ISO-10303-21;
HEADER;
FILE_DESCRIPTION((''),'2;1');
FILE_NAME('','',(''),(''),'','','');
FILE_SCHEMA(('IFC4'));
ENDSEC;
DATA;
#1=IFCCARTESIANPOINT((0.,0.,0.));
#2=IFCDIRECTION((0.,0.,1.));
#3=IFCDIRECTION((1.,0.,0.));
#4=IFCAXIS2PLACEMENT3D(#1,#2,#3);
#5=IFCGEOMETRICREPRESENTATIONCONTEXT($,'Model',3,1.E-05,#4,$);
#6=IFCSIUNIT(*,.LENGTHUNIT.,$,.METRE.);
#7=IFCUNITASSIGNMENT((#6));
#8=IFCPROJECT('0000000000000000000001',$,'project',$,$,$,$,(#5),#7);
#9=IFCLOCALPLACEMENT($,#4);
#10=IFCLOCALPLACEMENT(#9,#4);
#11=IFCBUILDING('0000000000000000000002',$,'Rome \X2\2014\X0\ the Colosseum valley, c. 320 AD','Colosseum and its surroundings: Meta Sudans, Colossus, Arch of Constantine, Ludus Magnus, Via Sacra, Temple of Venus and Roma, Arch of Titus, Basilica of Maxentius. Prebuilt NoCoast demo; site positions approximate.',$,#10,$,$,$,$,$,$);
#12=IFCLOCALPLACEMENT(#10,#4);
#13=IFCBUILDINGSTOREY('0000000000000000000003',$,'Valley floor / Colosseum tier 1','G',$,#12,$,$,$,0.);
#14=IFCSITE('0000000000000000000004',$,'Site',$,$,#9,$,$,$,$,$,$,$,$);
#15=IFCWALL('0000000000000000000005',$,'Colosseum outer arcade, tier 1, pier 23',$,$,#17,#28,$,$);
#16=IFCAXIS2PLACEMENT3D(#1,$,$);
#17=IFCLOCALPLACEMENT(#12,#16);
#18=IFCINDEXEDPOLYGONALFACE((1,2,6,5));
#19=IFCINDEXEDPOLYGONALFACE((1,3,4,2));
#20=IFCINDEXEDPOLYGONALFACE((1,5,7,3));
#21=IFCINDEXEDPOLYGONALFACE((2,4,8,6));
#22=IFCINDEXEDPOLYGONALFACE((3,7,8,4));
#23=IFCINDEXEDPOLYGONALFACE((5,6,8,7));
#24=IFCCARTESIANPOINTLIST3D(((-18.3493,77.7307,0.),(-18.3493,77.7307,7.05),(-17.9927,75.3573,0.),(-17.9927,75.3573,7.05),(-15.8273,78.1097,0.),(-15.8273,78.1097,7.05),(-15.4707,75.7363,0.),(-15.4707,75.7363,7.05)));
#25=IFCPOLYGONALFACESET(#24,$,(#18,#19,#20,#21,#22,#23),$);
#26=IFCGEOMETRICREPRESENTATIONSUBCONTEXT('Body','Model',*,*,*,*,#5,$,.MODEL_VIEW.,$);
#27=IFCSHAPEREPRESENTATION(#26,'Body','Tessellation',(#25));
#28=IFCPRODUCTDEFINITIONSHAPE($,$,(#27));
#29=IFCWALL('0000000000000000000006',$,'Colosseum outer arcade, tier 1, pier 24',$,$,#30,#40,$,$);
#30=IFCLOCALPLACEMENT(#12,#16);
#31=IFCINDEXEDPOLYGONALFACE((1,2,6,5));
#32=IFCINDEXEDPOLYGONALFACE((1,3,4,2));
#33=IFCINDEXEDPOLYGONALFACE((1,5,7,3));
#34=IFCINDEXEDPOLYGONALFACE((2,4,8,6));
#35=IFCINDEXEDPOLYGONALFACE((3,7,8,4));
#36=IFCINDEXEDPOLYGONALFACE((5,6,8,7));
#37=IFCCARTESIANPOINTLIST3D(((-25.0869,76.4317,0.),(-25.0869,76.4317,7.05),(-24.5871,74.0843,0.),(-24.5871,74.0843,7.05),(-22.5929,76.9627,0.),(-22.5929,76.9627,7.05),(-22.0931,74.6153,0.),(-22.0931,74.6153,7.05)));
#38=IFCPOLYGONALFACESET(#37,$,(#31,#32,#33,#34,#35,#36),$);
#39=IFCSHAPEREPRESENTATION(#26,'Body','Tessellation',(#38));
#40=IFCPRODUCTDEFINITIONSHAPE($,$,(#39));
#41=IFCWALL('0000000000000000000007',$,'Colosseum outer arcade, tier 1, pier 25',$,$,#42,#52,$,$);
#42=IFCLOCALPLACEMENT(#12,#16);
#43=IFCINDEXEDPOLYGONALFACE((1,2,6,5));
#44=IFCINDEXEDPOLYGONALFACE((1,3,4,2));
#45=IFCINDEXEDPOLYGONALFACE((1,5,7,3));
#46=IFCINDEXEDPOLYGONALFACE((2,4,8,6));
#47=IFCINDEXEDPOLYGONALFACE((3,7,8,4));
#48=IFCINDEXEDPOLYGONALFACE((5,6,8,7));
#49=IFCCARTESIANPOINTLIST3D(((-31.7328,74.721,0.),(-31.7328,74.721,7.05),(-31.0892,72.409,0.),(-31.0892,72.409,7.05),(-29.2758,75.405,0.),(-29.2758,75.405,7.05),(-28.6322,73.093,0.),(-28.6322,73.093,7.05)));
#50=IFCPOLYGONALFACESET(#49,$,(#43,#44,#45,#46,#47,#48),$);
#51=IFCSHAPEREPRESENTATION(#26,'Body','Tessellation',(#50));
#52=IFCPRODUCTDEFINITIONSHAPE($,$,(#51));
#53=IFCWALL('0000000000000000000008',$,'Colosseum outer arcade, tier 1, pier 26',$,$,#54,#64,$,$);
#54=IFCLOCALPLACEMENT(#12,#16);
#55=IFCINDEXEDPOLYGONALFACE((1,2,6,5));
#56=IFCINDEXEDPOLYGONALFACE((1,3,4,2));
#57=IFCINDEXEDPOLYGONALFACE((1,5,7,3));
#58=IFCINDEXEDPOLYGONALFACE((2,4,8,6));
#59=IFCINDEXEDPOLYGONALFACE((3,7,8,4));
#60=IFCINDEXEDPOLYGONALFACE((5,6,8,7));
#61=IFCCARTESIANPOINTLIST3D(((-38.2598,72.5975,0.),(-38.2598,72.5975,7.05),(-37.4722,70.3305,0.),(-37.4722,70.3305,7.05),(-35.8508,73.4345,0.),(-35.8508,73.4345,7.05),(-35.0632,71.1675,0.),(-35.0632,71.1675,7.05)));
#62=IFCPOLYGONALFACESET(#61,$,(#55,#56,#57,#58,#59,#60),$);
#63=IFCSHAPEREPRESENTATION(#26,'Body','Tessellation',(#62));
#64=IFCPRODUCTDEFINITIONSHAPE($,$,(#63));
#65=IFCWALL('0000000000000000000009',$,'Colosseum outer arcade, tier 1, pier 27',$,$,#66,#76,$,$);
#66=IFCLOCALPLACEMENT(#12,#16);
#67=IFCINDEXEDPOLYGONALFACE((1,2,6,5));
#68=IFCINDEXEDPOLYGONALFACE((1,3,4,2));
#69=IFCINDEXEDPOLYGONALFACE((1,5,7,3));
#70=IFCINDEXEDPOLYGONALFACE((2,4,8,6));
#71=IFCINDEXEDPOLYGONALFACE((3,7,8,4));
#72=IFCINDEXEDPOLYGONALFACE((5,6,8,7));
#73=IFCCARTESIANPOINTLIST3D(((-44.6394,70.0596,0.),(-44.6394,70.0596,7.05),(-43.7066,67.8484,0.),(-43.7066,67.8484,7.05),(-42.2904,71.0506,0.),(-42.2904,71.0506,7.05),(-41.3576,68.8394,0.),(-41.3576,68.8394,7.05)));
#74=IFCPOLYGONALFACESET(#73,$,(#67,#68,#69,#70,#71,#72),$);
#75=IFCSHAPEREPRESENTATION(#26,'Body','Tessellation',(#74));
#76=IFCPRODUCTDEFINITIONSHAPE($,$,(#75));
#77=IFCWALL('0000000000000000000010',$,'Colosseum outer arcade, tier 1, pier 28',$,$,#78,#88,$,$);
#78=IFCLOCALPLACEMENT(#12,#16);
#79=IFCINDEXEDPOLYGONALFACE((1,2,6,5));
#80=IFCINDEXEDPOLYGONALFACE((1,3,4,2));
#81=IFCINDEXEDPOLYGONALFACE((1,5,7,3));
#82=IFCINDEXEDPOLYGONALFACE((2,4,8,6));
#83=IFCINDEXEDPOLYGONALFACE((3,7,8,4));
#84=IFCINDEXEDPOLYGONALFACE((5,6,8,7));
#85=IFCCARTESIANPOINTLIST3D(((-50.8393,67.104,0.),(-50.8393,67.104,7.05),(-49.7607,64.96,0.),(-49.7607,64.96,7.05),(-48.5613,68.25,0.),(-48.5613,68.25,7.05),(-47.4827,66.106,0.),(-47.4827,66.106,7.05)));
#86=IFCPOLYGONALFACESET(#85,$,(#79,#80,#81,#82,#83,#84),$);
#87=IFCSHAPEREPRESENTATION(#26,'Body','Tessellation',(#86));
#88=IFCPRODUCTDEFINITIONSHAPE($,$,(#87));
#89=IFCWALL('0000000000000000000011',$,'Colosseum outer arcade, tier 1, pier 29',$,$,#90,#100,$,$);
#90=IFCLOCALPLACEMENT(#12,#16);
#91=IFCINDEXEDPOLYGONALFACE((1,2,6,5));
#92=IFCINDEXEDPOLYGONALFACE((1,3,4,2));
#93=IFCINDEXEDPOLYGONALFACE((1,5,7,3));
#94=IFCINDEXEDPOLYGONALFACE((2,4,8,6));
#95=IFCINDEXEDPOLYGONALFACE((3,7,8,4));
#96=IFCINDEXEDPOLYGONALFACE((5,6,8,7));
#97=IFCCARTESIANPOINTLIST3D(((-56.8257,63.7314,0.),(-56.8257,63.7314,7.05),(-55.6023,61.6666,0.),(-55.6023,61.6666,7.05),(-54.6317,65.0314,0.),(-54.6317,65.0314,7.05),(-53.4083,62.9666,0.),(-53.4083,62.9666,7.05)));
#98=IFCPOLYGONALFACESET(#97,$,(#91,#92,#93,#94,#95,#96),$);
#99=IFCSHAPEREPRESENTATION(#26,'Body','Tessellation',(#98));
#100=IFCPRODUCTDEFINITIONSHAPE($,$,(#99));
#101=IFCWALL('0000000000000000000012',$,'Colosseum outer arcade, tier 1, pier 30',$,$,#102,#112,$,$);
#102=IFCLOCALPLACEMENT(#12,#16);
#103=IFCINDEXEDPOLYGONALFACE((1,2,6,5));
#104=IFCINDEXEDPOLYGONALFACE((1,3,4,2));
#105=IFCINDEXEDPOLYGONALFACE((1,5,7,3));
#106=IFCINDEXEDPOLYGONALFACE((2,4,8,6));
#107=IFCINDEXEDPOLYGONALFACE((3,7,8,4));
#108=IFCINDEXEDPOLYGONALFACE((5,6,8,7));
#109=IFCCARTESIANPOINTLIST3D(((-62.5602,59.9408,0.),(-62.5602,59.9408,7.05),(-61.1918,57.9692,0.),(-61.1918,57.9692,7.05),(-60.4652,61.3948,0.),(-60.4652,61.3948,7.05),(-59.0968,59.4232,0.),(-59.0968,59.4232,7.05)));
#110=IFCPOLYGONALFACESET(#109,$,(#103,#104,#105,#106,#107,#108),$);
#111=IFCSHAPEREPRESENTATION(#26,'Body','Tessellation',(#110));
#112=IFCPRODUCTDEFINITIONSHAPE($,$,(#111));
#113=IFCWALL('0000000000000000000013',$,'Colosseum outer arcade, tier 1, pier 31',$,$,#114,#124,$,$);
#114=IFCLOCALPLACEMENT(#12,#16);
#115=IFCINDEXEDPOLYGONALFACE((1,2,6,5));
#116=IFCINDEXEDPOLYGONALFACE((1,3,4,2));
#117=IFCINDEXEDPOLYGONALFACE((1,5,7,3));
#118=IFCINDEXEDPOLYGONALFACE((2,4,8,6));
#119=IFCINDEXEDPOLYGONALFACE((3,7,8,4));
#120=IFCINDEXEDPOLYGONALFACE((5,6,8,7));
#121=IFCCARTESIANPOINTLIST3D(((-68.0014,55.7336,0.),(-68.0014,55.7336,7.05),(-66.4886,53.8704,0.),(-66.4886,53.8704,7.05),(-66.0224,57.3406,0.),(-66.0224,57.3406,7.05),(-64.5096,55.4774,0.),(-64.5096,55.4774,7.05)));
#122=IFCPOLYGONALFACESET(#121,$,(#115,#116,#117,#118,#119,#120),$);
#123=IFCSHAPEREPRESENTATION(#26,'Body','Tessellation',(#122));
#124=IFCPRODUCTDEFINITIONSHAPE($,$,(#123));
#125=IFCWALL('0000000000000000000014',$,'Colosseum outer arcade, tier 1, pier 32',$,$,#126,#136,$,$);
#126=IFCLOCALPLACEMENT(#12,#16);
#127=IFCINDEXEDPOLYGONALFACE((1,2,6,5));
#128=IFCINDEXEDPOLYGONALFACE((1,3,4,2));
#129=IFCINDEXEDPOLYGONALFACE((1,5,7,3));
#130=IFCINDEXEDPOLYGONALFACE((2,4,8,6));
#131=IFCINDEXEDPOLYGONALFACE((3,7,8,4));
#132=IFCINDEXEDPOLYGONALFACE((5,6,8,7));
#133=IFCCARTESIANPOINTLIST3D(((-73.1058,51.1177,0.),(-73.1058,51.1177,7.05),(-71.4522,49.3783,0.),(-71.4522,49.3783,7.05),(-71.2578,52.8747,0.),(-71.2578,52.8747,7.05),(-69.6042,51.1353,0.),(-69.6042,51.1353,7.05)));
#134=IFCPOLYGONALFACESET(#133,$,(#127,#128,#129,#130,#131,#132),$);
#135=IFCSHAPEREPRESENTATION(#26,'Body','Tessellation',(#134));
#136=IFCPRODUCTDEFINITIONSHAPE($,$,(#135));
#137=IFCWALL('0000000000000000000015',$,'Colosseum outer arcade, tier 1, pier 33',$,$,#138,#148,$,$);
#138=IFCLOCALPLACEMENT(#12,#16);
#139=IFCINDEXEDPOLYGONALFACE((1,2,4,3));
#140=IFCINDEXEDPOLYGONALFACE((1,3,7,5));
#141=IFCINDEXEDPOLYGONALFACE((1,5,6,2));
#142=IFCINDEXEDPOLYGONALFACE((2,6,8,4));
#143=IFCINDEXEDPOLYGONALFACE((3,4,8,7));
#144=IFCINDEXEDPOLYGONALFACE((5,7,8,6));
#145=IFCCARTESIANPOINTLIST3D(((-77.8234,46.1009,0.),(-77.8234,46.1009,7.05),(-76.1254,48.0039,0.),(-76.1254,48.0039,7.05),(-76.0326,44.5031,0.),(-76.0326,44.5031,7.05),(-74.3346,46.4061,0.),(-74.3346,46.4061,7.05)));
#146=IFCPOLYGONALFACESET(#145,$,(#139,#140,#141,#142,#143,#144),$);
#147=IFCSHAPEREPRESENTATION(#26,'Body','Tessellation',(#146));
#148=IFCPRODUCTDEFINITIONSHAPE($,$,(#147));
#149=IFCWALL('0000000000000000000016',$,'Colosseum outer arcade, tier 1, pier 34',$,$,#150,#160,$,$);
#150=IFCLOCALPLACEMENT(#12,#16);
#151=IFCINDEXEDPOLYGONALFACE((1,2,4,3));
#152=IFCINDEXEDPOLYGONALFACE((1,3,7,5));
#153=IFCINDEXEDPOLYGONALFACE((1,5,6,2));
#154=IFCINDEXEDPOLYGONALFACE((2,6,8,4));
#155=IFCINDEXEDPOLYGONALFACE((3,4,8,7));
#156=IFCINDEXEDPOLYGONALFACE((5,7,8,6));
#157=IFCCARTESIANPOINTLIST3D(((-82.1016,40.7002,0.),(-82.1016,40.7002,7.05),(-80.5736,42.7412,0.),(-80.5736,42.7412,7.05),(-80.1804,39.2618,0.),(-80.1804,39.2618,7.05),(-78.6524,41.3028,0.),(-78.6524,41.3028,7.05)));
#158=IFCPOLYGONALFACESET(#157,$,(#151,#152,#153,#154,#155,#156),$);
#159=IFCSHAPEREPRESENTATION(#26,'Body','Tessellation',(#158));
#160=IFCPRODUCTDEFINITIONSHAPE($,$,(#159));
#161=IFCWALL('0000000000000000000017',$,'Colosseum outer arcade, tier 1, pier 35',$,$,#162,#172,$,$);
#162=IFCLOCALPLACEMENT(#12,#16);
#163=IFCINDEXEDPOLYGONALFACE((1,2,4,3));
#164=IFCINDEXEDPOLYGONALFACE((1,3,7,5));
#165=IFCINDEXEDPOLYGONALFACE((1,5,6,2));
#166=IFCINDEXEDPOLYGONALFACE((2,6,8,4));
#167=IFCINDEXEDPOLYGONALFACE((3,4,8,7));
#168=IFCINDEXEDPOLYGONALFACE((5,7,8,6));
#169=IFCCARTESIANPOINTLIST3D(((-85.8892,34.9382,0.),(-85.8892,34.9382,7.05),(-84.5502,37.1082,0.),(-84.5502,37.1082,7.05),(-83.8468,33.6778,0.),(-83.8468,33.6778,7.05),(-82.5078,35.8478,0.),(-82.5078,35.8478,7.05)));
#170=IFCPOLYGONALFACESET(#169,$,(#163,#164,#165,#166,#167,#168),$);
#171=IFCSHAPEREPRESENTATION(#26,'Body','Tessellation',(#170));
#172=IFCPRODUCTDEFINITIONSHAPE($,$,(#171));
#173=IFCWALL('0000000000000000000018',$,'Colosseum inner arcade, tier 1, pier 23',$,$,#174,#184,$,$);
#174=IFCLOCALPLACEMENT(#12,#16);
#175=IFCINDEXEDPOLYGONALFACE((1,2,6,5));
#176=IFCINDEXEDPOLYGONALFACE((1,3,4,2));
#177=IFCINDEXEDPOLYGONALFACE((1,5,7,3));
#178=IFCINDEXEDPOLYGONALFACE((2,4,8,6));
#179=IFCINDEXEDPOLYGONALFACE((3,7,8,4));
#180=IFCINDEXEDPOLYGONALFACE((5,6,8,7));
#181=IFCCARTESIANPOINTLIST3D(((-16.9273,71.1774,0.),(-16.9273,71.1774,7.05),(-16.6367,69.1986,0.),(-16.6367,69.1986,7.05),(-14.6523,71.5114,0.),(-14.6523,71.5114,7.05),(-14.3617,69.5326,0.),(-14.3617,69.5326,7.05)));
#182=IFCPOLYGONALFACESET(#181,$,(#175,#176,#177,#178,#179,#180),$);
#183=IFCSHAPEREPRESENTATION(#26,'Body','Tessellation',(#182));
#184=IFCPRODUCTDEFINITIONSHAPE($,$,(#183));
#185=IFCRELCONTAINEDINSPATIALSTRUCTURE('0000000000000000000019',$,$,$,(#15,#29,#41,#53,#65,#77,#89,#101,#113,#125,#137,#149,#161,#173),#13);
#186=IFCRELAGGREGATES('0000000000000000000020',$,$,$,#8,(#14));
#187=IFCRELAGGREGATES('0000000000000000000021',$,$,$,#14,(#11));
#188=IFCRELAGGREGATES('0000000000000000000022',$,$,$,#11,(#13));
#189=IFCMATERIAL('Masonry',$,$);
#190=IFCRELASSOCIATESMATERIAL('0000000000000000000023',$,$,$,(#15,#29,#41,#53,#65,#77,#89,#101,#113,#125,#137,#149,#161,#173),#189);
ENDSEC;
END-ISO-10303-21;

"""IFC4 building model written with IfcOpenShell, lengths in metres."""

from ifc_helpers import new_model, si_unit, frame, origin_with_axes, place, context, subcontext, project, spatial, indexed_curve, outline, extrude, material, element, save


model = new_model("IFC4")

# Units and contexts
model_context = context("Model", 3, precision=1e-05, world=origin_with_axes())
body_context = subcontext(model_context, "Body", "Model", "MODEL_VIEW")
ifc_project = project(units=[si_unit("LENGTHUNIT", "METRE")], contexts=[model_context])

# Site, building, storey
site_placement = place(None, origin_with_axes())
site = spatial("IfcSite", under=ifc_project, at=site_placement, Name="Site")
building_placement = place(site_placement, origin_with_axes())
building = spatial("IfcBuilding", under=site, at=building_placement, Name="Rome — the Colosseum valley, c. 320 AD", Description="Colosseum and its surroundings: Meta Sudans, Colossus, Arch of Constantine, Ludus Magnus, Via Sacra, Temple of Venus and Roma, Arch of Titus, Basilica of Maxentius. Prebuilt NoCoast demo; site positions approximate.")
storey_placement = place(building_placement, origin_with_axes())
storey = spatial("IfcBuildingStorey", under=building, at=storey_placement, Name="Valley floor / Colosseum tier 1", Description="G", Elevation=0.0)

# Walls
ifc_material = material(Name="Masonry")
wall_1_placement = place(storey_placement, frame((-15.649, 76.923, 0.0), z_axis=(0.0, 0.0, 1.0), x_axis=(-0.988896, -0.148609, 0.0)))
element("IfcWall", 1, at=wall_1_placement, inside=storey, material=ifc_material, Name="Colosseum outer arcade, tier 1, pier 23", context=body_context, shape_type="SweptSolid", body=[
    extrude(outline(indexed_curve([(0.0, 0.0), (0.0, 2.4), (2.5503, 2.4), (2.5503, 0.0), (0.0, 0.0)], self_intersect=False)), frame((0.0, -1.2, 0.0), z_axis=(0.0, 0.0, 1.0), x_axis=(1.0, 0.0, 0.0)), (0.0, 0.0, 1.0), 7.05),
])
wall_2_placement = place(storey_placement, frame((-22.343, 75.789, 0.0), z_axis=(0.0, 0.0, 1.0), x_axis=(-0.978077, -0.208243, 0.0)))
element("IfcWall", 2, at=wall_2_placement, inside=storey, material=ifc_material, Name="Colosseum outer arcade, tier 1, pier 24", context=body_context, shape_type="SweptSolid", body=[
    extrude(outline(indexed_curve([(0.0, 0.0), (0.0, 2.4), (2.5499, 2.4), (2.5499, 0.0), (0.0, 0.0)], self_intersect=False)), frame((0.0, -1.2, 0.0), z_axis=(0.0, 0.0, 1.0), x_axis=(1.0, 0.0, 0.0)), (0.0, 0.0, 1.0), 7.05),
])
wall_3_placement = place(storey_placement, frame((-28.954, 74.249, 0.0), z_axis=(0.0, 0.0, 1.0), x_axis=(-0.963366, -0.26819, 0.0)))
element("IfcWall", 3, at=wall_3_placement, inside=storey, material=ifc_material, Name="Colosseum outer arcade, tier 1, pier 25", context=body_context, shape_type="SweptSolid", body=[
    extrude(outline(indexed_curve([(0.0, 0.0), (0.0, 2.4), (2.5504, 2.4), (2.5504, 0.0), (0.0, 0.0)], self_intersect=False)), frame((0.0, -1.2, 0.0), z_axis=(0.0, 0.0, 1.0), x_axis=(1.0, 0.0, 0.0)), (0.0, 0.0, 1.0), 7.05),
])
wall_4_placement = place(storey_placement, frame((-35.457, 72.301, 0.0), z_axis=(0.0, 0.0, 1.0), x_axis=(-0.944608, -0.328201, 0.0)))
element("IfcWall", 4, at=wall_4_placement, inside=storey, material=ifc_material, Name="Colosseum outer arcade, tier 1, pier 26", context=body_context, shape_type="SweptSolid", body=[
    extrude(outline(indexed_curve([(0.0, 0.0), (0.0, 2.4), (2.5503, 2.4), (2.5503, 0.0), (0.0, 0.0)], self_intersect=False)), frame((0.0, -1.2, 0.0), z_axis=(0.0, 0.0, 1.0), x_axis=(1.0, 0.0, 0.0)), (0.0, 0.0, 1.0), 7.05),
])
wall_5_placement = place(storey_placement, frame((-41.824, 69.945, 0.0), z_axis=(0.0, 0.0, 1.0), x_axis=(-0.921362, -0.388706, 0.0)))
element("IfcWall", 5, at=wall_5_placement, inside=storey, material=ifc_material, Name="Colosseum outer arcade, tier 1, pier 27", context=body_context, shape_type="SweptSolid", body=[
    extrude(outline(indexed_curve([(0.0, 0.0), (0.0, 2.4), (2.5495, 2.4), (2.5495, 0.0), (0.0, 0.0)], self_intersect=False)), frame((0.0, -1.2, 0.0), z_axis=(0.0, 0.0, 1.0), x_axis=(1.0, 0.0, 0.0)), (0.0, 0.0, 1.0), 7.05),
])
wall_6_placement = place(storey_placement, frame((-48.022, 67.178, 0.0), z_axis=(0.0, 0.0, 1.0), x_axis=(-0.893326, -0.449408, 0.0)))
element("IfcWall", 6, at=wall_6_placement, inside=storey, material=ifc_material, Name="Colosseum outer arcade, tier 1, pier 28", context=body_context, shape_type="SweptSolid", body=[
    extrude(outline(indexed_curve([(0.0, 0.0), (0.0, 2.4), (2.55, 2.4), (2.55, 0.0), (0.0, 0.0)], self_intersect=False)), frame((0.0, -1.2, 0.0), z_axis=(0.0, 0.0, 1.0), x_axis=(1.0, 0.0, 0.0)), (0.0, 0.0, 1.0), 7.05),
])
wall_7_placement = place(storey_placement, frame((-54.02, 63.999, 0.0), z_axis=(0.0, 0.0, 1.0), x_axis=(-0.860317, -0.509759, 0.0)))
element("IfcWall", 7, at=wall_7_placement, inside=storey, material=ifc_material, Name="Colosseum outer arcade, tier 1, pier 29", context=body_context, shape_type="SweptSolid", body=[
    extrude(outline(indexed_curve([(0.0, 0.0), (0.0, 2.4), (2.5502, 2.4), (2.5502, 0.0), (0.0, 0.0)], self_intersect=False)), frame((0.0, -1.2, 0.0), z_axis=(0.0, 0.0, 1.0), x_axis=(1.0, 0.0, 0.0)), (0.0, 0.0, 1.0), 7.05),
])
wall_8_placement = place(storey_placement, frame((-59.781, 60.409, 0.0), z_axis=(0.0, 0.0, 1.0), x_axis=(-0.821528, -0.570168, 0.0)))
element("IfcWall", 8, at=wall_8_placement, inside=storey, material=ifc_material, Name="Colosseum outer arcade, tier 1, pier 30", context=body_context, shape_type="SweptSolid", body=[
    extrude(outline(indexed_curve([(0.0, 0.0), (0.0, 2.4), (2.5501, 2.4), (2.5501, 0.0), (0.0, 0.0)], self_intersect=False)), frame((0.0, -1.2, 0.0), z_axis=(0.0, 0.0, 1.0), x_axis=(1.0, 0.0, 0.0)), (0.0, 0.0, 1.0), 7.05),
])
wall_9_placement = place(storey_placement, frame((-65.266, 56.409, 0.0), z_axis=(0.0, 0.0, 1.0), x_axis=(-0.776294, -0.630371, 0.0)))
element("IfcWall", 9, at=wall_9_placement, inside=storey, material=ifc_material, Name="Colosseum outer arcade, tier 1, pier 31", context=body_context, shape_type="SweptSolid", body=[
    extrude(outline(indexed_curve([(0.0, 0.0), (0.0, 2.4), (2.5493, 2.4), (2.5493, 0.0), (0.0, 0.0)], self_intersect=False)), frame((0.0, -1.2, 0.0), z_axis=(0.0, 0.0, 1.0), x_axis=(1.0, 0.0, 0.0)), (0.0, 0.0, 1.0), 7.05),
])
wall_10_placement = place(storey_placement, frame((-70.431, 52.005, 0.0), z_axis=(0.0, 0.0, 1.0), x_axis=(-0.724725, -0.689038, 0.0)))
element("IfcWall", 10, at=wall_10_placement, inside=storey, material=ifc_material, Name="Colosseum outer arcade, tier 1, pier 32", context=body_context, shape_type="SweptSolid", body=[
    extrude(outline(indexed_curve([(0.0, 0.0), (0.0, 2.4), (2.5499, 2.4), (2.5499, 0.0), (0.0, 0.0)], self_intersect=False)), frame((0.0, -1.2, 0.0), z_axis=(0.0, 0.0, 1.0), x_axis=(1.0, 0.0, 0.0)), (0.0, 0.0, 1.0), 7.05),
])
wall_11_placement = place(storey_placement, frame((-75.23, 47.205, 0.0), z_axis=(0.0, 0.0, 1.0), x_axis=(-0.665774, -0.746153, 0.0)))
element("IfcWall", 11, at=wall_11_placement, inside=storey, material=ifc_material, Name="Colosseum outer arcade, tier 1, pier 33", context=body_context, shape_type="SweptSolid", body=[
    extrude(outline(indexed_curve([(0.0, 0.0), (0.0, 2.4), (2.5504, 2.4), (2.5504, 0.0), (0.0, 0.0)], self_intersect=False)), frame((0.0, -1.2, 0.0), z_axis=(0.0, 0.0, 1.0), x_axis=(1.0, 0.0, 0.0)), (0.0, 0.0, 1.0), 7.05),
])
wall_12_placement = place(storey_placement, frame((-79.613, 42.022, 0.0), z_axis=(0.0, 0.0, 1.0), x_axis=(-0.599309, -0.800517, 0.0)))
element("IfcWall", 12, at=wall_12_placement, inside=storey, material=ifc_material, Name="Colosseum outer arcade, tier 1, pier 34", context=body_context, shape_type="SweptSolid", body=[
    extrude(outline(indexed_curve([(0.0, 0.0), (0.0, 2.4), (2.5496, 2.4), (2.5496, 0.0), (0.0, 0.0)], self_intersect=False)), frame((0.0, -1.2, 0.0), z_axis=(0.0, 0.0, 1.0), x_axis=(1.0, 0.0, 0.0)), (0.0, 0.0, 1.0), 7.05),
])
wall_13_placement = place(storey_placement, frame((-83.529, 36.478, 0.0), z_axis=(0.0, 0.0, 1.0), x_axis=(-0.525125, -0.851025, 0.0)))
element("IfcWall", 13, at=wall_13_placement, inside=storey, material=ifc_material, Name="Colosseum outer arcade, tier 1, pier 35", context=body_context, shape_type="SweptSolid", body=[
    extrude(outline(indexed_curve([(0.0, 0.0), (0.0, 2.4), (2.5499, 2.4), (2.5499, 0.0), (0.0, 0.0)], self_intersect=False)), frame((0.0, -1.2, 0.0), z_axis=(0.0, 0.0, 1.0), x_axis=(1.0, 0.0, 0.0)), (0.0, 0.0, 1.0), 7.05),
])
wall_14_placement = place(storey_placement, frame((-14.507, 70.522, 0.0), z_axis=(0.0, 0.0, 1.0), x_axis=(-0.989394, -0.145256, 0.0)))
element("IfcWall", 14, at=wall_14_placement, inside=storey, material=ifc_material, Name="Colosseum inner arcade, tier 1, pier 23", context=body_context, shape_type="SweptSolid", body=[
    extrude(outline(indexed_curve([(0.0, 0.0), (0.0, 2.0), (2.2994, 2.0), (2.2994, 0.0), (0.0, 0.0)], self_intersect=False)), frame((0.0, -1.0, 0.0), z_axis=(0.0, 0.0, 1.0), x_axis=(1.0, 0.0, 0.0)), (0.0, 0.0, 1.0), 7.05),
])

save(model, "model.ifc")
